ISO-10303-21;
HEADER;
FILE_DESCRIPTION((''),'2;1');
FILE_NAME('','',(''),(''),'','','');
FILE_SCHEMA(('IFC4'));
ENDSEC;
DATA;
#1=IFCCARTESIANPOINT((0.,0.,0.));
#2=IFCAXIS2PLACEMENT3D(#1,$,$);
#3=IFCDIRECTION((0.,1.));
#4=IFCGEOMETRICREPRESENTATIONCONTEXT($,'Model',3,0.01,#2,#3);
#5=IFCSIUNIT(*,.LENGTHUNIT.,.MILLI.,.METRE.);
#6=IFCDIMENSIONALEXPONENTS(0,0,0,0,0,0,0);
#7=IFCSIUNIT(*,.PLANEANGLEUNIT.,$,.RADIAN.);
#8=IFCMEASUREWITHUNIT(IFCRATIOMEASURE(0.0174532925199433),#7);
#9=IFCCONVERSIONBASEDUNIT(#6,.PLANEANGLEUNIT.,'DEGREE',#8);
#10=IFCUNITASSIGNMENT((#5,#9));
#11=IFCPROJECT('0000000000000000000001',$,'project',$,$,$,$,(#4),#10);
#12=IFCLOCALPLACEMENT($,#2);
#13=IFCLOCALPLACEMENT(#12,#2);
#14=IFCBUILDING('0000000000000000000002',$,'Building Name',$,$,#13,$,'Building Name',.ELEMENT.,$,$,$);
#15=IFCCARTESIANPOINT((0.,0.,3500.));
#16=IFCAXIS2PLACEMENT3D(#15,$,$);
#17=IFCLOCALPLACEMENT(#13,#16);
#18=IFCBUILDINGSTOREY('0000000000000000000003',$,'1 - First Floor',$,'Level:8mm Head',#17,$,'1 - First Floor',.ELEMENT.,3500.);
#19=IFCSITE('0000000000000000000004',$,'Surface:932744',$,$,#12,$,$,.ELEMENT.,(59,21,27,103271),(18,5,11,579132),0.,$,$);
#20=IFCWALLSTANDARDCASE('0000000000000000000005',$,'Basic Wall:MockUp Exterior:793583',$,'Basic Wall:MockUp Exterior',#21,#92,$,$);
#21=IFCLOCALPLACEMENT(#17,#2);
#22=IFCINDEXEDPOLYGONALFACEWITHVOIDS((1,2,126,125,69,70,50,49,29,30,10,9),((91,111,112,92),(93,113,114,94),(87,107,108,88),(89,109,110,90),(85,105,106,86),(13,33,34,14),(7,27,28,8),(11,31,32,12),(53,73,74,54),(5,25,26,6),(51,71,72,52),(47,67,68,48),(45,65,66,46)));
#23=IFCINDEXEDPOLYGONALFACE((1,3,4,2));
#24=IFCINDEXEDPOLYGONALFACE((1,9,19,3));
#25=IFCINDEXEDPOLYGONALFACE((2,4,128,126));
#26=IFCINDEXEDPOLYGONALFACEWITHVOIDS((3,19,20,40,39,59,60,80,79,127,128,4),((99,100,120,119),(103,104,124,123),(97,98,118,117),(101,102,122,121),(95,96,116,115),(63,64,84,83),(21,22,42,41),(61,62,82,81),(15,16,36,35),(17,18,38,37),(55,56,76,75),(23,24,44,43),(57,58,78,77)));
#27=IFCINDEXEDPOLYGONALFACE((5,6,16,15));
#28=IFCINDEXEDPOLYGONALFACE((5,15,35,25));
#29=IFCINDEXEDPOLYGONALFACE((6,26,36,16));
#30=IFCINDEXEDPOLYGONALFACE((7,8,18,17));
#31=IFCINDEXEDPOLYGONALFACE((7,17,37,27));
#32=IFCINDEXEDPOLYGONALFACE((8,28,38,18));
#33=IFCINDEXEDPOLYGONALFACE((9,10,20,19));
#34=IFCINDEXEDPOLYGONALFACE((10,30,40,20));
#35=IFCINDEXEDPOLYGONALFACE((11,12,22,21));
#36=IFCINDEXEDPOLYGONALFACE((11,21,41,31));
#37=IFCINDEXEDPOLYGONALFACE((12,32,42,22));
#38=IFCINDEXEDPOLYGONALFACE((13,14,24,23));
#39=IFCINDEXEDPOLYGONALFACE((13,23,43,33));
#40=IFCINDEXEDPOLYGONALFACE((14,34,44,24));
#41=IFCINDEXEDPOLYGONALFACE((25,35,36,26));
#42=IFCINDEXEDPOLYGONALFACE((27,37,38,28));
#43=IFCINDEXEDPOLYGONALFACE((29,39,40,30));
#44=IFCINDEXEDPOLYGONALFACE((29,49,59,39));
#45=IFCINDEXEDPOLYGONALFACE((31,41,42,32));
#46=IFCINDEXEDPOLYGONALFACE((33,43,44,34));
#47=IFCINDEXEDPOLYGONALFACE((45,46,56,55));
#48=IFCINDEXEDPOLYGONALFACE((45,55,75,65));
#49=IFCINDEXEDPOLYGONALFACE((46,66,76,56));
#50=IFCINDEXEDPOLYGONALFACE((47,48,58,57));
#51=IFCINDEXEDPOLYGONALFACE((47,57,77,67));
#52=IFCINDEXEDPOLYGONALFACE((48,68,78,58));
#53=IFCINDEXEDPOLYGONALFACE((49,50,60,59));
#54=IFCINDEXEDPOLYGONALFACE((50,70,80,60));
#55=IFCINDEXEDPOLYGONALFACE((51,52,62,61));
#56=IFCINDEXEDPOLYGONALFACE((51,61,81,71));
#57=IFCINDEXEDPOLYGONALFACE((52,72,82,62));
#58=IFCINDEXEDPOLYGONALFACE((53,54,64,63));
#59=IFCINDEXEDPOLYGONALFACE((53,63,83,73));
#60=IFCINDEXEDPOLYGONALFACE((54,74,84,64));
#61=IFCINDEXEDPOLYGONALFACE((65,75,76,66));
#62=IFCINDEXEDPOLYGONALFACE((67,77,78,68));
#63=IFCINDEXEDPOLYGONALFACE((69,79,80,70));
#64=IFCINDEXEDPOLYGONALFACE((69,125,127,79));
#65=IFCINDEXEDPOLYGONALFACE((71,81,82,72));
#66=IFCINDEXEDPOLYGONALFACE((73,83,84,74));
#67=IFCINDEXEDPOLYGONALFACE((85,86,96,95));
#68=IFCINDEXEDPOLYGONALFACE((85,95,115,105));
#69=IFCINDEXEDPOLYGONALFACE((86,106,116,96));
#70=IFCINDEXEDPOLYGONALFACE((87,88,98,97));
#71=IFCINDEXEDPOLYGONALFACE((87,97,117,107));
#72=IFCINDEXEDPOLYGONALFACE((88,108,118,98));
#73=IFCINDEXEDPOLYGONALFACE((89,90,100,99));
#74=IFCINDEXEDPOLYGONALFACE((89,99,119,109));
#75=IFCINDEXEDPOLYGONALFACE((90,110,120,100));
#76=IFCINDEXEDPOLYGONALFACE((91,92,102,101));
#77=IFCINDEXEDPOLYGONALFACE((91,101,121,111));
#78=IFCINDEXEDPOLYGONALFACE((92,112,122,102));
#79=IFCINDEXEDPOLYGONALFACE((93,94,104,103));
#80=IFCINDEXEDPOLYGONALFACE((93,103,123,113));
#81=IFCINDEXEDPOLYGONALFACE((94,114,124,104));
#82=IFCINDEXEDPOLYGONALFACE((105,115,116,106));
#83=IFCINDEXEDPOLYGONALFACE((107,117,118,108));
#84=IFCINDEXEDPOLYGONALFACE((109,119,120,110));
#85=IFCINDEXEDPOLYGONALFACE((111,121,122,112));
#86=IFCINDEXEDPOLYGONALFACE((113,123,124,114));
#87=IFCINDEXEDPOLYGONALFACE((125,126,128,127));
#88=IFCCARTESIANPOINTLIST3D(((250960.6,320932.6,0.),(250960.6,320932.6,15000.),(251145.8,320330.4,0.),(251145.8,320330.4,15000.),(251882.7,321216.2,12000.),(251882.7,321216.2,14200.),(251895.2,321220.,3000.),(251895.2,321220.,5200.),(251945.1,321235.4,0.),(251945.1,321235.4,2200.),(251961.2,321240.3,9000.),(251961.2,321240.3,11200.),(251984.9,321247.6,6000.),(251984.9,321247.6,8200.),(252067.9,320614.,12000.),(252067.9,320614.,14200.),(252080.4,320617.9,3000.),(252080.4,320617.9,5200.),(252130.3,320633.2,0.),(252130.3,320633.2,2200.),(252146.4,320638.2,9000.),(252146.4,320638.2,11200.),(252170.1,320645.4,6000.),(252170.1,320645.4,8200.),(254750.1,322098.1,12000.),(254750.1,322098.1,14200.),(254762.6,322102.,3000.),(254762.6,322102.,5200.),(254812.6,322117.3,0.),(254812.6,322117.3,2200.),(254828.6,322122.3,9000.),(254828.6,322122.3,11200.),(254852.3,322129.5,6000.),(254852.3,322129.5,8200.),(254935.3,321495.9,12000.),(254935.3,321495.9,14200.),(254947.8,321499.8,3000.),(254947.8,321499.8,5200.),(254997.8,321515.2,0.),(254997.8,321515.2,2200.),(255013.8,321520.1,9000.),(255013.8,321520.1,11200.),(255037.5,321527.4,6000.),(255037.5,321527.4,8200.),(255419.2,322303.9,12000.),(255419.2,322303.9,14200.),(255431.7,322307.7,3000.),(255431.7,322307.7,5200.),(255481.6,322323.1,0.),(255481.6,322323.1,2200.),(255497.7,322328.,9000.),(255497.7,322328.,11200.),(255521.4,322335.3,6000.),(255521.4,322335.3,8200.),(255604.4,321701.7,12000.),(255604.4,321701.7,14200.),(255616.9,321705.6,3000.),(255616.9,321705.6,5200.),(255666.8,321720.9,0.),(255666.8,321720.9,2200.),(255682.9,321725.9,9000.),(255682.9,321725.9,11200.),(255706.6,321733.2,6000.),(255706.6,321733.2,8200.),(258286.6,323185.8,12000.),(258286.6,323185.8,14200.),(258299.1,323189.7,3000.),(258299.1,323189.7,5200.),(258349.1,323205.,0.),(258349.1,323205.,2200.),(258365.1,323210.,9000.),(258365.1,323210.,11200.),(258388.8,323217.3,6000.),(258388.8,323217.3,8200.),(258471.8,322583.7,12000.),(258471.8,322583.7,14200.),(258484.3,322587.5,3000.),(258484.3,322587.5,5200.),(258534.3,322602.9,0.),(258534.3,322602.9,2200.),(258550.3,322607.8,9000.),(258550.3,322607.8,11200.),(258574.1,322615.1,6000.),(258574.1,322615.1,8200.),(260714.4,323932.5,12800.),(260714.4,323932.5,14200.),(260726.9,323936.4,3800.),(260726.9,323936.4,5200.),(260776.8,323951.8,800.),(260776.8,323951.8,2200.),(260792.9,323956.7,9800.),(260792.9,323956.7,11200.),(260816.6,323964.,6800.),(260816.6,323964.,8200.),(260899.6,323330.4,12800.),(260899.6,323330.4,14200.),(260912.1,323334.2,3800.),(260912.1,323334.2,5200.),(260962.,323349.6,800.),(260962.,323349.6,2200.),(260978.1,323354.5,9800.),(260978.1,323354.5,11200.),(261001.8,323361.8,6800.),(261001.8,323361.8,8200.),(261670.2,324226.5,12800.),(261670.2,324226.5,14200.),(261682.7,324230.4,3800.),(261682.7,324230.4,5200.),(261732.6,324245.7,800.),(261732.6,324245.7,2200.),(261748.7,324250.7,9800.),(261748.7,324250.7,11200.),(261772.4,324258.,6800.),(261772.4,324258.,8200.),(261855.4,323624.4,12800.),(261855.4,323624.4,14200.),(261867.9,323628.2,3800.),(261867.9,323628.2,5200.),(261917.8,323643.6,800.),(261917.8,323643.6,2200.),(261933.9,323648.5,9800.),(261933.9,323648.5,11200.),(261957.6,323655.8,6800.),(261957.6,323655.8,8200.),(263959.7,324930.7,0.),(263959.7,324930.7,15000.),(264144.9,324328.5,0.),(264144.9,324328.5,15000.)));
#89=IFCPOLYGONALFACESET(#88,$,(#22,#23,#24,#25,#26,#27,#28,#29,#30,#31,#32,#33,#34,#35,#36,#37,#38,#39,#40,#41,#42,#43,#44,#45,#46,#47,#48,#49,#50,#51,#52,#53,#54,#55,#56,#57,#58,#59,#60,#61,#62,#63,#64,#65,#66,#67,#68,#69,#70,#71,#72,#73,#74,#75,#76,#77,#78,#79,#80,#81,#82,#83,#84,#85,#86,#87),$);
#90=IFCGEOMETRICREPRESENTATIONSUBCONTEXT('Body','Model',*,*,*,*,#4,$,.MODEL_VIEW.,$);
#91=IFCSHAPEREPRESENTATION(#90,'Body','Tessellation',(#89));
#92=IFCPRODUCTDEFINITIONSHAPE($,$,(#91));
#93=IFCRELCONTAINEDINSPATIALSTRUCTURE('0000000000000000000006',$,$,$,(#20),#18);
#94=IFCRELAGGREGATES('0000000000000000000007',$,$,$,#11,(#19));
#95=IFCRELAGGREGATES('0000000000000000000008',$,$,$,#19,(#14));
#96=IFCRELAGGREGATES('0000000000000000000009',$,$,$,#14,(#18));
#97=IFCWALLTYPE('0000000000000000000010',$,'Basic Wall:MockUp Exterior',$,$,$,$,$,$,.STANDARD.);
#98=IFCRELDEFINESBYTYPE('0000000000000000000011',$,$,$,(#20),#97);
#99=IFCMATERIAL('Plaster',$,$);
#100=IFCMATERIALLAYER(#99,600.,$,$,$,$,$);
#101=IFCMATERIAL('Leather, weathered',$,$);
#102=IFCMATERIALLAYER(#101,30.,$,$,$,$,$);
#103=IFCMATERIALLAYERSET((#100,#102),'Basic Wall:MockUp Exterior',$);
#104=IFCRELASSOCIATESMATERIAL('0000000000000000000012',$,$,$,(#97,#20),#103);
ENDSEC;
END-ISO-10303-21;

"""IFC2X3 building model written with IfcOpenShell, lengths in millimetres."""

from ifc_helpers import new_model, entity, si_unit, converted_unit, direction, frame, frame_2d, origin, place, context, subcontext, project, spatial, rectangle, extrude, material, layer, layer_set, layer_usage, type_object, element, save


model = new_model("IFC2X3")

# Units and contexts
model_context = context("Model", 3, precision=0.01, world=origin(), true_north=direction((0.0, 1.0)))
body_context = subcontext(model_context, "Body", "Model", "MODEL_VIEW")
ifc_project = project(units=[si_unit("LENGTHUNIT", "METRE", prefix="MILLI"), converted_unit("PLANEANGLEUNIT", "DEGREE", entity("IfcRatioMeasure", 0.0174532925199433), si_unit("PLANEANGLEUNIT", "RADIAN"), dimensions=[0, 0, 0, 0, 0, 0, 0])], contexts=[model_context])

# Site, building, storey
site_placement = place(None, origin())
site = spatial("IfcSite", under=ifc_project, at=site_placement, Name="Surface:932744", CompositionType="ELEMENT", RefLatitude=(59, 21, 27, 103271), RefLongitude=(18, 5, 11, 579132), RefElevation=0.0)
building_placement = place(site_placement, origin())
building = spatial("IfcBuilding", under=site, at=building_placement, Name="Building Name", LongName="Building Name", CompositionType="ELEMENT")
storey_placement = place(building_placement, frame((0.0, 0.0, 3500.0)))
storey = spatial("IfcBuildingStorey", under=building, at=storey_placement, Name="1 - First Floor", ObjectType="Level:8mm Head", LongName="1 - First Floor", CompositionType="ELEMENT", Elevation=3500.0)

# Shared definitions
ifc_material_1 = material(Name="Leather, weathered")

# Wall, openings
ifc_material_2 = material(Name="Plaster")
ifc_layer_1 = layer(ifc_material_2, 600.0)
ifc_layer_2 = layer(ifc_material_1, 30.0)
ifc_layer_set_1 = layer_set([ifc_layer_1, ifc_layer_2], Name="Basic Wall:MockUp Exterior")
ifc_layer_usage_1 = layer_usage(ifc_layer_set_1, "AXIS2", "POSITIVE", -315.0)
wall_type_1 = type_object("IfcWallType", Name="Basic Wall:MockUp Exterior", PredefinedType="STANDARD", material=ifc_layer_set_1)
wall_1_placement = place(storey_placement, frame((264052.3, 324629.6, 0.0), z_axis=(0.0, 0.0, 1.0), x_axis=(-0.955811, -0.29398, 0.0)))
wall_1 = element("IfcWallStandardCase", 1, at=wall_1_placement, inside=storey, type_object=wall_type_1, material=ifc_layer_usage_1, Name="Basic Wall:MockUp Exterior:793583", ObjectType="Basic Wall:MockUp Exterior", context=body_context, shape_type="SweptSolid", body=[
    extrude(rectangle(XDim=13600.0, YDim=630.0, at=frame_2d((6800.0, 0.0), x_axis=(-1.0, 0.0))), origin(), (0.0, 0.0, 1.0), 15000.0),
])
opening_1_placement = place(wall_1_placement, frame((12570.0, 315.0, 0.0)))
element("IfcOpeningElement", 2, at=opening_1_placement, cuts=wall_1, ObjectType="Opening", context=body_context, shape_type="SweptSolid", body=[
    extrude(rectangle(XDim=2200.0, YDim=3000.0, at=frame_2d((1100.0, 1500.0), x_axis=(1.0, 0.0))), frame((0.0, 0.0, 0.0), z_axis=(0.0, -1.0, 0.0), x_axis=(0.0, 0.0, 1.0)), (0.0, 0.0, 1.0), 630.0),
])
opening_2_placement = place(wall_1_placement, frame((8870.0, 315.0, 0.0)))
element("IfcOpeningElement", 3, at=opening_2_placement, cuts=wall_1, ObjectType="Opening", context=body_context, shape_type="SweptSolid", body=[
    extrude(rectangle(XDim=2200.0, YDim=3000.0, at=frame_2d((1100.0, 1500.0), x_axis=(1.0, 0.0))), frame((0.0, 0.0, 0.0), z_axis=(0.0, -1.0, 0.0), x_axis=(0.0, 0.0, 1.0)), (0.0, 0.0, 1.0), 630.0),
])
opening_3_placement = place(wall_1_placement, frame((3330.0, 315.0, 800.0)))
element("IfcOpeningElement", 4, at=opening_3_placement, cuts=wall_1, ObjectType="Opening", context=body_context, shape_type="SweptSolid", body=[
    extrude(rectangle(XDim=1400.0, YDim=1000.0, at=frame_2d((700.0, 500.0), x_axis=(1.0, 0.0))), frame((0.0, 0.0, 0.0), z_axis=(0.0, -1.0, 0.0), x_axis=(0.0, 0.0, 1.0)), (0.0, 0.0, 1.0), 630.0),
])
opening_4_placement = place(wall_1_placement, frame((12528.4, 315.0, 6000.0)))
element("IfcOpeningElement", 5, at=opening_4_placement, cuts=wall_1, ObjectType="Opening", context=body_context, shape_type="SweptSolid", body=[
    extrude(rectangle(XDim=2200.0, YDim=3000.0, at=frame_2d((1100.0, 1500.0), x_axis=(1.0, 0.0))), frame((0.0, 0.0, 0.0), z_axis=(0.0, -1.0, 0.0), x_axis=(0.0, 0.0, 1.0)), (0.0, 0.0, 1.0), 630.0),
])
opening_5_placement = place(wall_1_placement, frame((8828.4, 315.0, 6000.0)))
element("IfcOpeningElement", 6, at=opening_5_placement, cuts=wall_1, ObjectType="Opening", context=body_context, shape_type="SweptSolid", body=[
    extrude(rectangle(XDim=2200.0, YDim=3000.0, at=frame_2d((1100.0, 1500.0), x_axis=(1.0, 0.0))), frame((0.0, 0.0, 0.0), z_axis=(0.0, -1.0, 0.0), x_axis=(0.0, 0.0, 1.0)), (0.0, 0.0, 1.0), 630.0),
])
opening_6_placement = place(wall_1_placement, frame((3288.4, 315.0, 6800.0)))
element("IfcOpeningElement", 7, at=opening_6_placement, cuts=wall_1, ObjectType="Opening", context=body_context, shape_type="SweptSolid", body=[
    extrude(rectangle(XDim=1400.0, YDim=1000.0, at=frame_2d((700.0, 500.0), x_axis=(1.0, 0.0))), frame((0.0, 0.0, 0.0), z_axis=(0.0, -1.0, 0.0), x_axis=(0.0, 0.0, 1.0)), (0.0, 0.0, 1.0), 630.0),
])
opening_7_placement = place(wall_1_placement, frame((12553.2, 315.0, 9000.0)))
element("IfcOpeningElement", 8, at=opening_7_placement, cuts=wall_1, ObjectType="Opening", context=body_context, shape_type="SweptSolid", body=[
    extrude(rectangle(XDim=2200.0, YDim=3000.0, at=frame_2d((1100.0, 1500.0), x_axis=(1.0, 0.0))), frame((0.0, 0.0, 0.0), z_axis=(0.0, -1.0, 0.0), x_axis=(0.0, 0.0, 1.0)), (0.0, 0.0, 1.0), 630.0),
])
opening_8_placement = place(wall_1_placement, frame((8853.2, 315.0, 9000.0)))
element("IfcOpeningElement", 9, at=opening_8_placement, cuts=wall_1, ObjectType="Opening", context=body_context, shape_type="SweptSolid", body=[
    extrude(rectangle(XDim=2200.0, YDim=3000.0, at=frame_2d((1100.0, 1500.0), x_axis=(1.0, 0.0))), frame((0.0, 0.0, 0.0), z_axis=(0.0, -1.0, 0.0), x_axis=(0.0, 0.0, 1.0)), (0.0, 0.0, 1.0), 630.0),
])
opening_9_placement = place(wall_1_placement, frame((3313.2, 315.0, 9800.0)))
element("IfcOpeningElement", 10, at=opening_9_placement, cuts=wall_1, ObjectType="Opening", context=body_context, shape_type="SweptSolid", body=[
    extrude(rectangle(XDim=1400.0, YDim=1000.0, at=frame_2d((700.0, 500.0), x_axis=(1.0, 0.0))), frame((0.0, 0.0, 0.0), z_axis=(0.0, -1.0, 0.0), x_axis=(0.0, 0.0, 1.0)), (0.0, 0.0, 1.0), 630.0),
])
opening_10_placement = place(wall_1_placement, frame((12635.3, 315.0, 12000.0)))
element("IfcOpeningElement", 11, at=opening_10_placement, cuts=wall_1, ObjectType="Opening", context=body_context, shape_type="SweptSolid", body=[
    extrude(rectangle(XDim=2200.0, YDim=3000.0, at=frame_2d((1100.0, 1500.0), x_axis=(1.0, 0.0))), frame((0.0, 0.0, 0.0), z_axis=(0.0, -1.0, 0.0), x_axis=(0.0, 0.0, 1.0)), (0.0, 0.0, 1.0), 630.0),
])
opening_11_placement = place(wall_1_placement, frame((8935.3, 315.0, 12000.0)))
element("IfcOpeningElement", 12, at=opening_11_placement, cuts=wall_1, ObjectType="Opening", context=body_context, shape_type="SweptSolid", body=[
    extrude(rectangle(XDim=2200.0, YDim=3000.0, at=frame_2d((1100.0, 1500.0), x_axis=(1.0, 0.0))), frame((0.0, 0.0, 0.0), z_axis=(0.0, -1.0, 0.0), x_axis=(0.0, 0.0, 1.0)), (0.0, 0.0, 1.0), 630.0),
])
opening_12_placement = place(wall_1_placement, frame((3395.3, 315.0, 12800.0)))
element("IfcOpeningElement", 13, at=opening_12_placement, cuts=wall_1, ObjectType="Opening", context=body_context, shape_type="SweptSolid", body=[
    extrude(rectangle(XDim=1400.0, YDim=1000.0, at=frame_2d((700.0, 500.0), x_axis=(1.0, 0.0))), frame((0.0, 0.0, 0.0), z_axis=(0.0, -1.0, 0.0), x_axis=(0.0, 0.0, 1.0)), (0.0, 0.0, 1.0), 630.0),
])
opening_13_placement = place(wall_1_placement, frame((12622.2, 315.0, 3000.0)))
element("IfcOpeningElement", 14, at=opening_13_placement, cuts=wall_1, ObjectType="Opening", context=body_context, shape_type="SweptSolid", body=[
    extrude(rectangle(XDim=2200.0, YDim=3000.0, at=frame_2d((1100.0, 1500.0), x_axis=(1.0, 0.0))), frame((0.0, 0.0, 0.0), z_axis=(0.0, -1.0, 0.0), x_axis=(0.0, 0.0, 1.0)), (0.0, 0.0, 1.0), 630.0),
])
opening_14_placement = place(wall_1_placement, frame((8922.2, 315.0, 3000.0)))
element("IfcOpeningElement", 15, at=opening_14_placement, cuts=wall_1, ObjectType="Opening", context=body_context, shape_type="SweptSolid", body=[
    extrude(rectangle(XDim=2200.0, YDim=3000.0, at=frame_2d((1100.0, 1500.0), x_axis=(1.0, 0.0))), frame((0.0, 0.0, 0.0), z_axis=(0.0, -1.0, 0.0), x_axis=(0.0, 0.0, 1.0)), (0.0, 0.0, 1.0), 630.0),
])
opening_15_placement = place(wall_1_placement, frame((3382.3, 315.0, 3800.0)))
element("IfcOpeningElement", 16, at=opening_15_placement, cuts=wall_1, ObjectType="Opening", context=body_context, shape_type="SweptSolid", body=[
    extrude(rectangle(XDim=1400.0, YDim=1000.0, at=frame_2d((700.0, 500.0), x_axis=(1.0, 0.0))), frame((0.0, 0.0, 0.0), z_axis=(0.0, -1.0, 0.0), x_axis=(0.0, 0.0, 1.0)), (0.0, 0.0, 1.0), 630.0),
])

save(model, "model.ifc")
